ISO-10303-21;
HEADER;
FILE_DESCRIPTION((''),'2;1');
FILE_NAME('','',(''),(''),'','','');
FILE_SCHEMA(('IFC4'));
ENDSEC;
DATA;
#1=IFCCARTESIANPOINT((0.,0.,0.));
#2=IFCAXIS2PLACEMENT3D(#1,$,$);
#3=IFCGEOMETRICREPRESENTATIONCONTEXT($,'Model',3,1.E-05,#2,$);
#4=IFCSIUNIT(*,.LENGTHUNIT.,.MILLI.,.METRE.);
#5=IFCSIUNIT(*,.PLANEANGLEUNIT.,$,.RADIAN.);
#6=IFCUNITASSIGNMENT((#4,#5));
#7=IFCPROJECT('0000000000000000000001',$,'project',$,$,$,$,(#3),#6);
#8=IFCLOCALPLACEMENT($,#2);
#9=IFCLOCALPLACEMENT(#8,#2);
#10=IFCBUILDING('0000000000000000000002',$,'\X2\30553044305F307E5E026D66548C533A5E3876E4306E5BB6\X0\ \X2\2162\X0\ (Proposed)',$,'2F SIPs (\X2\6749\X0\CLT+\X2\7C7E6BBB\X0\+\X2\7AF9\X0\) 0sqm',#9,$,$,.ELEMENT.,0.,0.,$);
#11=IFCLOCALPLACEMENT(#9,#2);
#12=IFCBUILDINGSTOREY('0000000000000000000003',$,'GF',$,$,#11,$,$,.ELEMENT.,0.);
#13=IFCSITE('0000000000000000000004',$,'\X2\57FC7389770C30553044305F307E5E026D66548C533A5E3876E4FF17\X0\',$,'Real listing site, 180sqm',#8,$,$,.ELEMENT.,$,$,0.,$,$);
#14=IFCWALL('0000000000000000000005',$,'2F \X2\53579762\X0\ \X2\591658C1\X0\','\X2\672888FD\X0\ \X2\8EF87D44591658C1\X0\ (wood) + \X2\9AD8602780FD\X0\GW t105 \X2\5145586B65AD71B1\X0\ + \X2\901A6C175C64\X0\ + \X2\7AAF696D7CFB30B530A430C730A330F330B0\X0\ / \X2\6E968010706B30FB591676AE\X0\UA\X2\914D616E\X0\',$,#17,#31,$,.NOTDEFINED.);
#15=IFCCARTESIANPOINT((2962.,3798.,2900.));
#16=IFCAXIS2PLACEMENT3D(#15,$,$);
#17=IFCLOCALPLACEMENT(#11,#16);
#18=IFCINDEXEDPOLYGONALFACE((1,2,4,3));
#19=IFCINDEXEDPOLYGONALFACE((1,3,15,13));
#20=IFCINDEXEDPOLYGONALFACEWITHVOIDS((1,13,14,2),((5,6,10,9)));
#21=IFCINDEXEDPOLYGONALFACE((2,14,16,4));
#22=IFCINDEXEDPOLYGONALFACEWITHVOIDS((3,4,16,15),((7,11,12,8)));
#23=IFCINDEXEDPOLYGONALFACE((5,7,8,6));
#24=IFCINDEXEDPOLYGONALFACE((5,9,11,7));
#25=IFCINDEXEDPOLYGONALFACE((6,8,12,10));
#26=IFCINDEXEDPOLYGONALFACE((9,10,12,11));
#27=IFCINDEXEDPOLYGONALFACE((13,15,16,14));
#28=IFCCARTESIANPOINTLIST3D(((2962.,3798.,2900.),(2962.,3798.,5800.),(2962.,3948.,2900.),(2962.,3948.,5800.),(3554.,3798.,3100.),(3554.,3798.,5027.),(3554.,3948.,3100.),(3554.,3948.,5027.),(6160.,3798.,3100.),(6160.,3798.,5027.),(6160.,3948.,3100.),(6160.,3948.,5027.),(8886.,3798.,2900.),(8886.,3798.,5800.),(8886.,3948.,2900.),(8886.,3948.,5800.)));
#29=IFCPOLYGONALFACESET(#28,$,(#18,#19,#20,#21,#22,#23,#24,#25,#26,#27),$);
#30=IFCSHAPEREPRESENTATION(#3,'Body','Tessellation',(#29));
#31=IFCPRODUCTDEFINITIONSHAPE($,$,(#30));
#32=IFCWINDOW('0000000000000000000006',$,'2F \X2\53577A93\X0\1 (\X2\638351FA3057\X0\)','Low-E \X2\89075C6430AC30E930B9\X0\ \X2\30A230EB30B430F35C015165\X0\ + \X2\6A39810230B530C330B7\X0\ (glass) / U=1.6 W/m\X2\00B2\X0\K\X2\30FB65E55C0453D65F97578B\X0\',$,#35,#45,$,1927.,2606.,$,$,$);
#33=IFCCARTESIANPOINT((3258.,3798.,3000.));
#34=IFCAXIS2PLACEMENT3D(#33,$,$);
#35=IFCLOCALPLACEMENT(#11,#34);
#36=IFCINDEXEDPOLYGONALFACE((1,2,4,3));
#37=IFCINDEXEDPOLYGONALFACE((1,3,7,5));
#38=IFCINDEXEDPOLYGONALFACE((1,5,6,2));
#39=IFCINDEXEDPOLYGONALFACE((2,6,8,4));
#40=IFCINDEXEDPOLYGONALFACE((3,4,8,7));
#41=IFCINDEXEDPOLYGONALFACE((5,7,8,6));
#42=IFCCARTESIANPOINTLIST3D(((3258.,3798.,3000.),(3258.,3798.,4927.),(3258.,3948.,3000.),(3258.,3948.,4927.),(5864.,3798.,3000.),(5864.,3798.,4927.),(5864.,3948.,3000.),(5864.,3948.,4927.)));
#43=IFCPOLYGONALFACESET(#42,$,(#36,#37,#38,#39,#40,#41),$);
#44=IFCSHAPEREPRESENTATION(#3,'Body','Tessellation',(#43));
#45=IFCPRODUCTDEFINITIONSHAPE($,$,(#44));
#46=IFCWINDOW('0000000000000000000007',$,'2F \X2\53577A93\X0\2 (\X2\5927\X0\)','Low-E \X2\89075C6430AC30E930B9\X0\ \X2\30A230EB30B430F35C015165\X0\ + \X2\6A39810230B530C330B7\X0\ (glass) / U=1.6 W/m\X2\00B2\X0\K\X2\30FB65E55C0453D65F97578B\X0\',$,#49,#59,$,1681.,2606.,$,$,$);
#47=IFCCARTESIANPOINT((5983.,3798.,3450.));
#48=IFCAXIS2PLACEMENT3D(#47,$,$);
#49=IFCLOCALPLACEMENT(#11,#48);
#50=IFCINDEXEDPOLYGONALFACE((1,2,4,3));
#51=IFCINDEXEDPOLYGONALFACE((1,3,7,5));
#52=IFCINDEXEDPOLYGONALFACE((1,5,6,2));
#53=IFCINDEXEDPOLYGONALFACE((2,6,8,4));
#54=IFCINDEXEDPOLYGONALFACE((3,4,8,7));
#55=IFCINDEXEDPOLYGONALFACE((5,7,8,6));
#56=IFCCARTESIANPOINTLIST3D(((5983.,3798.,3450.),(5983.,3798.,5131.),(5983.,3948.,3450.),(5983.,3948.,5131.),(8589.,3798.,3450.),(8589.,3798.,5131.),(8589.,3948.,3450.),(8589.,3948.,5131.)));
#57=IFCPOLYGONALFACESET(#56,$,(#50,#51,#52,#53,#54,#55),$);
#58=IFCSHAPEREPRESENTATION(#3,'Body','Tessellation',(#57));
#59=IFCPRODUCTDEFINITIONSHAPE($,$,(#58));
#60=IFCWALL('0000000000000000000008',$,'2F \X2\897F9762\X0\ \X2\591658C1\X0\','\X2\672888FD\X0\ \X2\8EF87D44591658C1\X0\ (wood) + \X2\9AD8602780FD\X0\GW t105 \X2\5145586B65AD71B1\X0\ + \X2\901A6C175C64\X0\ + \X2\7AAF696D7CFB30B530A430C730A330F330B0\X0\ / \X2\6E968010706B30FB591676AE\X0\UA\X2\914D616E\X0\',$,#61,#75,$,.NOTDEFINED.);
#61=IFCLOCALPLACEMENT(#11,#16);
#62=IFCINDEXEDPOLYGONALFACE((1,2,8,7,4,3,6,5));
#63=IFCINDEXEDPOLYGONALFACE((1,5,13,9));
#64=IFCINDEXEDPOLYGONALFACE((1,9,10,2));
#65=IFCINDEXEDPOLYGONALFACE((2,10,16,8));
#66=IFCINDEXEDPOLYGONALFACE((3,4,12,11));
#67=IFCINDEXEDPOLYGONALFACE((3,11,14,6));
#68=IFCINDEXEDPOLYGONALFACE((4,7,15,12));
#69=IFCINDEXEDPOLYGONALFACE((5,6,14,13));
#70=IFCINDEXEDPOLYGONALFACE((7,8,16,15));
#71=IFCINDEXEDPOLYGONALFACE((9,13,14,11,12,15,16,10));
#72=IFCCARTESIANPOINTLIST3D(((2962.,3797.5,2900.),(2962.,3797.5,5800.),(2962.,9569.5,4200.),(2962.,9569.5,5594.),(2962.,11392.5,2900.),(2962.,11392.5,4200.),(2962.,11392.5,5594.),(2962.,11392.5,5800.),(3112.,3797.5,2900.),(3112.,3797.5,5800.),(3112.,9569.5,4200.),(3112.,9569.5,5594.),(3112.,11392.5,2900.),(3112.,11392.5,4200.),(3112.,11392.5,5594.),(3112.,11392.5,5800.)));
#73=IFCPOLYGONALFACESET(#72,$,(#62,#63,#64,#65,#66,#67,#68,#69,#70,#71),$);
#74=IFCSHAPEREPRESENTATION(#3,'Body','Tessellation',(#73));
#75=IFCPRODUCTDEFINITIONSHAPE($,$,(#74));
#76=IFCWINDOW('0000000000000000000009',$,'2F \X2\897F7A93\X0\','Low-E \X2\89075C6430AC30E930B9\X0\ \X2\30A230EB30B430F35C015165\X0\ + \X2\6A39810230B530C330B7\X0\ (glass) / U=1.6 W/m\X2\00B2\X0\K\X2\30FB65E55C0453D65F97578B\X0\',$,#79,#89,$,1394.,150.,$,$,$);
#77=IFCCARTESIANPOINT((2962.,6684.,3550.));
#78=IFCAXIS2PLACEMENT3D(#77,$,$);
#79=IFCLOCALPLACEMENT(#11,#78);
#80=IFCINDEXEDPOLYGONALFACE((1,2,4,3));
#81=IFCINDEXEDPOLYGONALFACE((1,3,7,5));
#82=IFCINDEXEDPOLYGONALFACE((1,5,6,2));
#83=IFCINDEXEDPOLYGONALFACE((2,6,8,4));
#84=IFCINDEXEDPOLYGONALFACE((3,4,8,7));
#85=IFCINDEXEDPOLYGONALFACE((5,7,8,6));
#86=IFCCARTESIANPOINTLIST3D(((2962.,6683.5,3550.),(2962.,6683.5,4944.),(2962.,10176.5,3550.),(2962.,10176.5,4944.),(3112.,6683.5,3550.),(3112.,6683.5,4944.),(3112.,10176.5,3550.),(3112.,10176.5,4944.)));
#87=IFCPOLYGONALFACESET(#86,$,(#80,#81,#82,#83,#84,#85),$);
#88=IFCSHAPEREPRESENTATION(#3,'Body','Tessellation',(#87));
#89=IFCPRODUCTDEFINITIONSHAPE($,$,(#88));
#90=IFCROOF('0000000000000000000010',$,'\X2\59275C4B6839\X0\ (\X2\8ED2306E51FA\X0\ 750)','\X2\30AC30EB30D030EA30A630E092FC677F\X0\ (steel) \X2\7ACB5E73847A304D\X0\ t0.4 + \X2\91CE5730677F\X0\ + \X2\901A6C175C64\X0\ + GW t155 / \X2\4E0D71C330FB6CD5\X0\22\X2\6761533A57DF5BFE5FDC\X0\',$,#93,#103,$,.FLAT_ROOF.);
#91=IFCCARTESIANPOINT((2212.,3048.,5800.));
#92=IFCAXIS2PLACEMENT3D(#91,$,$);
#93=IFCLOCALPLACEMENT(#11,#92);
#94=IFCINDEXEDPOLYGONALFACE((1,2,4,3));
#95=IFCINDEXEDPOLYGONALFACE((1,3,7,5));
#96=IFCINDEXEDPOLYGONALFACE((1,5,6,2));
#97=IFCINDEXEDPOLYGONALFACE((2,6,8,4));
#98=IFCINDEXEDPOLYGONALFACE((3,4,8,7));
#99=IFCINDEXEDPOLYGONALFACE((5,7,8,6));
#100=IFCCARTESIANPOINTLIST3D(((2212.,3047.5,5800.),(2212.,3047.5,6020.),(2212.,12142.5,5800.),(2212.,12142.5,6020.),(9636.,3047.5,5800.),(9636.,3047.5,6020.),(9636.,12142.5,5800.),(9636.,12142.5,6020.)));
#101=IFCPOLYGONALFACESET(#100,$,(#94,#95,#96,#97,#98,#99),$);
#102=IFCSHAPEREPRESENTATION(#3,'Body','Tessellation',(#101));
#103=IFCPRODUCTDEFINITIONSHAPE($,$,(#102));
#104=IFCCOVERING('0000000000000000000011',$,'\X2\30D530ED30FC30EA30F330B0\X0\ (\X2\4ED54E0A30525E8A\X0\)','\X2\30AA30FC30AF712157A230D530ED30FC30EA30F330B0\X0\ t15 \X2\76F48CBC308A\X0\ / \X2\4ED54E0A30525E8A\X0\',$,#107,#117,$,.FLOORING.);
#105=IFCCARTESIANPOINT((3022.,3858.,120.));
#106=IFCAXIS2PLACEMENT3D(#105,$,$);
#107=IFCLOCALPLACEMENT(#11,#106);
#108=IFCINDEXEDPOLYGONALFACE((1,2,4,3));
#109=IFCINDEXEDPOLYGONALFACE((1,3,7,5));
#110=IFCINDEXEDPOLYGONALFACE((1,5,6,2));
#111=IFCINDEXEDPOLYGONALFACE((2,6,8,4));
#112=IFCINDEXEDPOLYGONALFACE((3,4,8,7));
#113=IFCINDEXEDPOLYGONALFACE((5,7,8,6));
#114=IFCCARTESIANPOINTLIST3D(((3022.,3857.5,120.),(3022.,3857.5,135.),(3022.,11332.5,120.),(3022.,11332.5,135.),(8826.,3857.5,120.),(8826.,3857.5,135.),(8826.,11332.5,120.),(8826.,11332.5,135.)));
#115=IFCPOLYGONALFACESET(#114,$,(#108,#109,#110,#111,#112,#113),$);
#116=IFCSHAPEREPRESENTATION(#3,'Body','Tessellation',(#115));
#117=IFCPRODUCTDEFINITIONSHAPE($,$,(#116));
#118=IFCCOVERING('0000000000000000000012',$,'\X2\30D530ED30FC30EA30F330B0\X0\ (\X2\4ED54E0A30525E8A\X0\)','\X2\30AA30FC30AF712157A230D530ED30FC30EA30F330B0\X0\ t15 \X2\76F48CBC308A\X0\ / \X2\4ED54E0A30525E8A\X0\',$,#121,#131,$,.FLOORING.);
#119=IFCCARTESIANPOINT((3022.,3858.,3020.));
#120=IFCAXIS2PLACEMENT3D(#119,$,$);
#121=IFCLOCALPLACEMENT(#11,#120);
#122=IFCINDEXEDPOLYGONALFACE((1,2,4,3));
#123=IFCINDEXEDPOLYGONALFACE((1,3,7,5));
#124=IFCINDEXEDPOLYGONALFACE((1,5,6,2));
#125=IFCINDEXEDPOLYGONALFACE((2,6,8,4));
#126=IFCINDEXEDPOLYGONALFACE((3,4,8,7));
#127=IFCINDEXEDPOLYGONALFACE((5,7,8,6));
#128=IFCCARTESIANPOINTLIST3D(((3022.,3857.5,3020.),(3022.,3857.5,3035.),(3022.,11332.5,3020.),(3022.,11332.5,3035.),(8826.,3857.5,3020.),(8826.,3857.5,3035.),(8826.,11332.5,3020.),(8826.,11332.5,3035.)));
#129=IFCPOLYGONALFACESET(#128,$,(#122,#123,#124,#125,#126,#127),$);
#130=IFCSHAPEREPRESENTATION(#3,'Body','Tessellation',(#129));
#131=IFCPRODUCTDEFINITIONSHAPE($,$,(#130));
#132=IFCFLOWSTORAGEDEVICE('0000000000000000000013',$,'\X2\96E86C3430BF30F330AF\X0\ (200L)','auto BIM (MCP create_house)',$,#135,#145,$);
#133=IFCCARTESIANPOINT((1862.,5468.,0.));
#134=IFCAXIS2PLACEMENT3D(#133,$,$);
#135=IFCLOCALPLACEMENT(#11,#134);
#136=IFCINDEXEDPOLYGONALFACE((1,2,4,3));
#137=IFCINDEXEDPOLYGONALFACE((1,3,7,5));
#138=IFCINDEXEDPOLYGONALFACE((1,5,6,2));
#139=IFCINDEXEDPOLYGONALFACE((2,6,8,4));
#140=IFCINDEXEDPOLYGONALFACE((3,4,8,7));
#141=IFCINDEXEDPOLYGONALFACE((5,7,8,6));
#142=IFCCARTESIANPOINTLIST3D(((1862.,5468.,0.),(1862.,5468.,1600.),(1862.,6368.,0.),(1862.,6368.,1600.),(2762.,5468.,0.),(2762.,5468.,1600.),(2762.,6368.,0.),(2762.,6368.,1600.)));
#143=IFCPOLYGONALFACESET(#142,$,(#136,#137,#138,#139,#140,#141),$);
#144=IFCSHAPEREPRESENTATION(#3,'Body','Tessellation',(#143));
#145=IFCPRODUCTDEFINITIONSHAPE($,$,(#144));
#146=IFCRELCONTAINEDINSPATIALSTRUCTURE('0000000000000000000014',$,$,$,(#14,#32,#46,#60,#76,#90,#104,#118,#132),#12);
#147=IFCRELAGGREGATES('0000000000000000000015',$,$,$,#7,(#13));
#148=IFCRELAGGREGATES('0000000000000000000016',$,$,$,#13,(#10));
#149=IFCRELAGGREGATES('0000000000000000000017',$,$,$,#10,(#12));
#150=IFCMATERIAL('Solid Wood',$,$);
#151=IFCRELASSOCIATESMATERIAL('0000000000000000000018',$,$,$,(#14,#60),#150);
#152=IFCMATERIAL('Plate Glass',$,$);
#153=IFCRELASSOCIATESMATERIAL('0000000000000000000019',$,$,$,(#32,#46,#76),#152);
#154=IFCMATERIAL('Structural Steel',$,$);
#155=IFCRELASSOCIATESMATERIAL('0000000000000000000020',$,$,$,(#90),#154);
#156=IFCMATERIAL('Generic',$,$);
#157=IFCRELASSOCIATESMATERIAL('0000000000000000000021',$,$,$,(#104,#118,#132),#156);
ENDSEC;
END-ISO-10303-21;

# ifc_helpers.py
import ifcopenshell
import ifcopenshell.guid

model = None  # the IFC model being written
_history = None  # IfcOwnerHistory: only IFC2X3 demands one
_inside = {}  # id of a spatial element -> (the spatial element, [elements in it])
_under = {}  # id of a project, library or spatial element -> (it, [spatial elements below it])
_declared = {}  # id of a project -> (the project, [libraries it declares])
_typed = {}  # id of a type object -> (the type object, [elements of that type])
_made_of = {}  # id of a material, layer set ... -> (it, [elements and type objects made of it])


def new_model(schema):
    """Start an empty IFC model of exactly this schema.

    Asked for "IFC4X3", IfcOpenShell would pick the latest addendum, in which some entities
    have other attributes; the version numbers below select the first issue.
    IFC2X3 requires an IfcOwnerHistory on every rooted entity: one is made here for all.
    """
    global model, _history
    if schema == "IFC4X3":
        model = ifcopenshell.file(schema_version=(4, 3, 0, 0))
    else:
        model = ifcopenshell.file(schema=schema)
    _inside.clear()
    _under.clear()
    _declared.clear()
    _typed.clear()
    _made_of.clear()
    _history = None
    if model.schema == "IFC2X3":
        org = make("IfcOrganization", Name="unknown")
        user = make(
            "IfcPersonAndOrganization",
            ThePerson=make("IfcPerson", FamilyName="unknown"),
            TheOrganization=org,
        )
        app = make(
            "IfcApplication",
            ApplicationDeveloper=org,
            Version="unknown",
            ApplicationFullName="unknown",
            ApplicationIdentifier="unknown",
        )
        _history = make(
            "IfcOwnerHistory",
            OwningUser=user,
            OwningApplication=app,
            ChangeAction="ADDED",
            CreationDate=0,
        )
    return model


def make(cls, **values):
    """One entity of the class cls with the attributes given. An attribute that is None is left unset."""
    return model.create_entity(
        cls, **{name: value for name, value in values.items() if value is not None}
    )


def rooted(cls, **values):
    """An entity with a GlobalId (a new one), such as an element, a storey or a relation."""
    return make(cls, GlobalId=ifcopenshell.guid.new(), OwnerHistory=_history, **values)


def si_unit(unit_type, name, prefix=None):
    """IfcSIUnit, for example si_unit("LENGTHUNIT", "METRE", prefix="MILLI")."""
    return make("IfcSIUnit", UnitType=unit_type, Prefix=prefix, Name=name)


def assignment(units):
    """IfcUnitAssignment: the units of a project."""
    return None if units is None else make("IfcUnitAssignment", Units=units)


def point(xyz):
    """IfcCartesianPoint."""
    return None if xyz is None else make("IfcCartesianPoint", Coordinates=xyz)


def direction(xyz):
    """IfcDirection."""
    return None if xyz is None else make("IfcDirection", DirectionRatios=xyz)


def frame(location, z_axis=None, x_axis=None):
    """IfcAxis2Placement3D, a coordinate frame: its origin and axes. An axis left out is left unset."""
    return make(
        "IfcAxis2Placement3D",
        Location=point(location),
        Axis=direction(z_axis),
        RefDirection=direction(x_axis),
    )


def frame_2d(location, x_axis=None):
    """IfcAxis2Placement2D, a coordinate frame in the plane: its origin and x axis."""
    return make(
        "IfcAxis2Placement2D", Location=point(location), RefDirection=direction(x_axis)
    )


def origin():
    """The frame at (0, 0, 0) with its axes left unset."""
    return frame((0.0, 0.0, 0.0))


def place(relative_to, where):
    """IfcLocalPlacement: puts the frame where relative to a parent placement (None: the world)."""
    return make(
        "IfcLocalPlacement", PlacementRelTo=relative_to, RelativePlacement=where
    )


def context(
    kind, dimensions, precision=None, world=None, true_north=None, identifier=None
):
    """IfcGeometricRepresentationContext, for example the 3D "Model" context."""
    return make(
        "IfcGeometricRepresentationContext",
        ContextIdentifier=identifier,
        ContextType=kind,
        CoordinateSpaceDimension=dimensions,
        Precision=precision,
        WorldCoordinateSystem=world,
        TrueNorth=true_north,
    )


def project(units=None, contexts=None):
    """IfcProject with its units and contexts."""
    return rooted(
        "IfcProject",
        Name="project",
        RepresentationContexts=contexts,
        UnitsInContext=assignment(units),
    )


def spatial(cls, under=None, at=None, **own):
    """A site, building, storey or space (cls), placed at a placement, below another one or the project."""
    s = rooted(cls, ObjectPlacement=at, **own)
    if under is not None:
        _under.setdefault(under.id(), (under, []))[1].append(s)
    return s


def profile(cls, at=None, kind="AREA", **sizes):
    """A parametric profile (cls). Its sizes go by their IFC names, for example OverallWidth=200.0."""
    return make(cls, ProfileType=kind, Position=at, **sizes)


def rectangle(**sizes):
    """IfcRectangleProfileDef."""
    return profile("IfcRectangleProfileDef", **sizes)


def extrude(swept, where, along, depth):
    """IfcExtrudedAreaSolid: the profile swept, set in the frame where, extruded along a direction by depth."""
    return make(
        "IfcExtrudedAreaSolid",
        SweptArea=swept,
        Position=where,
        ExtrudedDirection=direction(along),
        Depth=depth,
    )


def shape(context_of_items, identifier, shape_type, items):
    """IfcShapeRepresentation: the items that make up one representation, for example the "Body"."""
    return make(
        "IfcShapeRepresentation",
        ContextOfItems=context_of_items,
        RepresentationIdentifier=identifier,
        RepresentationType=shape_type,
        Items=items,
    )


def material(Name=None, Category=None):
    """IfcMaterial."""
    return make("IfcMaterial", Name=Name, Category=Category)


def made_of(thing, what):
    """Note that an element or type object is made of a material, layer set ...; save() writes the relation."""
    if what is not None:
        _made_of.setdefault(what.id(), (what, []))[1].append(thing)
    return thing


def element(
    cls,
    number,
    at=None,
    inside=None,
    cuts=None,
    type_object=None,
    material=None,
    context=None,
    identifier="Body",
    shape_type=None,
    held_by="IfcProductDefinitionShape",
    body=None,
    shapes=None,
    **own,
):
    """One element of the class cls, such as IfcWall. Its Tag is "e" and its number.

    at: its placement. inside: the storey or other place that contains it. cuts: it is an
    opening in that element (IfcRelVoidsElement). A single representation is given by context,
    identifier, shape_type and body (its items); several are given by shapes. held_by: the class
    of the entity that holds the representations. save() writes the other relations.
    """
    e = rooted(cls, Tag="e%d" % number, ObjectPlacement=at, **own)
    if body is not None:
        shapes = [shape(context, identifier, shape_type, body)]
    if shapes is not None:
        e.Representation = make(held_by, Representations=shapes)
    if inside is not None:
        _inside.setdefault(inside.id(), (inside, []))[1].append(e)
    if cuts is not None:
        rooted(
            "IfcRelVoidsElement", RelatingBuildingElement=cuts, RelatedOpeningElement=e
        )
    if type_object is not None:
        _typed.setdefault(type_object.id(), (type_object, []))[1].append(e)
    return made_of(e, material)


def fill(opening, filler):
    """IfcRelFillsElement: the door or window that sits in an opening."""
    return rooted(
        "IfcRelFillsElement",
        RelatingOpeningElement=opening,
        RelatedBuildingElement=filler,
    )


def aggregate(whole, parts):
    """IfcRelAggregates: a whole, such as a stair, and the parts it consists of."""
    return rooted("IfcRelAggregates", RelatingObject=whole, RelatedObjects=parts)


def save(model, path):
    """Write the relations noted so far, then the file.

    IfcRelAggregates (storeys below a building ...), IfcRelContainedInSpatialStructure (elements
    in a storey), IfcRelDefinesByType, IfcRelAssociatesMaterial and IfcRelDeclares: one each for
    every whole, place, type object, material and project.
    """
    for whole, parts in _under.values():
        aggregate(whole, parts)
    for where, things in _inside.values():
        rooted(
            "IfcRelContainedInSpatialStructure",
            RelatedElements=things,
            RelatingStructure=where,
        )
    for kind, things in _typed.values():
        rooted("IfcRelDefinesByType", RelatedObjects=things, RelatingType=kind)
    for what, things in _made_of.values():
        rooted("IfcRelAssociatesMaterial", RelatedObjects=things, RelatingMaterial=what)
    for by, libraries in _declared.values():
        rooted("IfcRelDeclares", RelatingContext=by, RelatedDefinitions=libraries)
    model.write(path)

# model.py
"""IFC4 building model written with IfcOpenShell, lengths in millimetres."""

from ifc_helpers import new_model, si_unit, frame, frame_2d, origin, place, context, project, spatial, rectangle, extrude, material, element, fill, save


model = new_model("IFC4")

# Units and contexts
model_context = context("Model", 3, precision=1e-05, world=origin())
ifc_project = project(units=[si_unit("LENGTHUNIT", "METRE", prefix="MILLI"), si_unit("PLANEANGLEUNIT", "RADIAN")], contexts=[model_context])

# Site, building, storey
site_placement = place(None, origin())
site = spatial("IfcSite", under=ifc_project, at=site_placement, Name="埼玉県さいたま市浦和区常盤７", ObjectType="Real listing site, 180sqm", CompositionType="ELEMENT", RefElevation=0.0)
building_placement = place(site_placement, origin())
building = spatial("IfcBuilding", under=site, at=building_placement, Name="さいたま市浦和区常盤の家 Ⅲ (Proposed)", ObjectType="2F SIPs (杉CLT+籾殻+竹) 0sqm", CompositionType="ELEMENT", ElevationOfRefHeight=0.0, ElevationOfTerrain=0.0)
storey_placement = place(building_placement, origin())
storey = spatial("IfcBuildingStorey", under=building, at=storey_placement, Name="GF", CompositionType="ELEMENT", Elevation=0.0)

# Shared definitions
ifc_material_1 = material(Name="Solid Wood")

# Shared definitions
ifc_material_2 = material(Name="Plate Glass")

# Wall, openings, windows
wall_1_placement = place(storey_placement, frame((2962.0, 3798.0, 2900.0)))
wall_1 = element("IfcWall", 1, at=wall_1_placement, inside=storey, material=ifc_material_1, Name="2F 南面 外壁", Description="木製 軸組外壁 (wood) + 高性能GW t105 充填断熱 + 通気層 + 窯業系サイディング / 準耐火・外皮UA配慮", PredefinedType="NOTDEFINED", context=model_context, shape_type="SweptSolid", body=[
    extrude(rectangle(XDim=5924.0, YDim=150.0, at=frame_2d((2962.0, 75.0))), frame((2962.0, 3798.0, 2900.0)), (0.0, 0.0, 1.0), 2900.0),
])
opening_1_placement = place(storey_placement, frame((3258.0, 3798.0, 3000.0)))
opening_1 = element("IfcOpeningElement", 2, at=opening_1_placement, cuts=wall_1, PredefinedType="NOTDEFINED", context=model_context, shape_type="SweptSolid", body=[
    extrude(rectangle(XDim=2606.0, YDim=150.0, at=frame_2d((1303.0, 75.0))), frame((3258.0, 3798.0, 3000.0)), (0.0, 0.0, 1.0), 1927.0),
])
opening_2_placement = place(storey_placement, frame((5983.0, 3798.0, 3450.0)))
opening_2 = element("IfcOpeningElement", 3, at=opening_2_placement, cuts=wall_1, PredefinedType="NOTDEFINED", context=model_context, shape_type="SweptSolid", body=[
    extrude(rectangle(XDim=2606.0, YDim=150.0, at=frame_2d((1303.0, 75.0))), frame((5983.0, 3798.0, 3450.0)), (0.0, 0.0, 1.0), 1681.0),
])
window_1_placement = place(storey_placement, frame((3258.0, 3798.0, 3000.0)))
window_1 = element("IfcWindow", 4, at=window_1_placement, inside=storey, material=ifc_material_2, Name="2F 南窓1 (掃出し)", Description="Low-E 複層ガラス アルゴン封入 + 樹脂サッシ (glass) / U=1.6 W/m²K・日射取得型", OverallHeight=1927.0, OverallWidth=2606.0, context=model_context, shape_type="SweptSolid", body=[
    extrude(rectangle(XDim=2606.0, YDim=150.0, at=frame_2d((1303.0, 75.0))), frame((3258.0, 3798.0, 3000.0)), (0.0, 0.0, 1.0), 1927.0),
])
fill(opening_1, window_1)
window_2_placement = place(storey_placement, frame((5983.0, 3798.0, 3450.0)))
window_2 = element("IfcWindow", 5, at=window_2_placement, inside=storey, material=ifc_material_2, Name="2F 南窓2 (大)", Description="Low-E 複層ガラス アルゴン封入 + 樹脂サッシ (glass) / U=1.6 W/m²K・日射取得型", OverallHeight=1681.0, OverallWidth=2606.0, context=model_context, shape_type="SweptSolid", body=[
    extrude(rectangle(XDim=2606.0, YDim=150.0, at=frame_2d((1303.0, 75.0))), frame((5983.0, 3798.0, 3450.0)), (0.0, 0.0, 1.0), 1681.0),
])
fill(opening_2, window_2)

# Wall, opening, window
wall_2_placement = place(storey_placement, frame((2962.0, 3798.0, 2900.0)))
wall_2 = element("IfcWall", 6, at=wall_2_placement, inside=storey, material=ifc_material_1, Name="2F 西面 外壁", Description="木製 軸組外壁 (wood) + 高性能GW t105 充填断熱 + 通気層 + 窯業系サイディング / 準耐火・外皮UA配慮", PredefinedType="NOTDEFINED", context=model_context, shape_type="SweptSolid", body=[
    extrude(rectangle(XDim=150.0, YDim=7595.0, at=frame_2d((75.0, 3797.0))), frame((2962.0, 3798.0, 2900.0)), (0.0, 0.0, 1.0), 2900.0),
])
opening_3_placement = place(storey_placement, frame((2962.0, 6684.0, 3550.0)))
opening_3 = element("IfcOpeningElement", 7, at=opening_3_placement, cuts=wall_2, PredefinedType="NOTDEFINED", context=model_context, shape_type="SweptSolid", body=[
    extrude(rectangle(XDim=150.0, YDim=3493.0, at=frame_2d((75.0, 1746.0))), frame((2962.0, 6684.0, 3550.0)), (0.0, 0.0, 1.0), 1394.0),
])
window_3_placement = place(storey_placement, frame((2962.0, 6684.0, 3550.0)))
window_3 = element("IfcWindow", 8, at=window_3_placement, inside=storey, material=ifc_material_2, Name="2F 西窓", Description="Low-E 複層ガラス アルゴン封入 + 樹脂サッシ (glass) / U=1.6 W/m²K・日射取得型", OverallHeight=1394.0, OverallWidth=150.0, context=model_context, shape_type="SweptSolid", body=[
    extrude(rectangle(XDim=150.0, YDim=3493.0, at=frame_2d((75.0, 1746.0))), frame((2962.0, 6684.0, 3550.0)), (0.0, 0.0, 1.0), 1394.0),
])
fill(opening_3, window_3)

# Roof
ifc_material_3 = material(Name="Structural Steel")
roof_placement = place(storey_placement, frame((2212.0, 3048.0, 5800.0)))
element("IfcRoof", 9, at=roof_placement, inside=storey, material=ifc_material_3, Name="大屋根 (軒の出 750)", Description="ガルバリウム鋼板 (steel) 立平葺き t0.4 + 野地板 + 通気層 + GW t155 / 不燃・法22条区域対応", PredefinedType="FLAT_ROOF", context=model_context, shape_type="SweptSolid", body=[
    extrude(rectangle(XDim=7424.0, YDim=9095.0, at=frame_2d((3712.0, 4547.0))), frame((2212.0, 3048.0, 5800.0)), (0.0, 0.0, 1.0), 220.0),
])

# Coverings
ifc_material_4 = material(Name="Generic")
covering_1_placement = place(storey_placement, frame((3022.0, 3858.0, 120.0)))
element("IfcCovering", 10, at=covering_1_placement, inside=storey, material=ifc_material_4, Name="フローリング (仕上げ床)", Description="オーク無垢フローリング t15 直貼り / 仕上げ床", PredefinedType="FLOORING", context=model_context, shape_type="SweptSolid", body=[
    extrude(rectangle(XDim=5804.0, YDim=7475.0, at=frame_2d((2902.0, 3737.0))), frame((3022.0, 3858.0, 120.0)), (0.0, 0.0, 1.0), 15.0),
])
covering_2_placement = place(storey_placement, frame((3022.0, 3858.0, 3020.0)))
element("IfcCovering", 11, at=covering_2_placement, inside=storey, material=ifc_material_4, Name="フローリング (仕上げ床)", Description="オーク無垢フローリング t15 直貼り / 仕上げ床", PredefinedType="FLOORING", context=model_context, shape_type="SweptSolid", body=[
    extrude(rectangle(XDim=5804.0, YDim=7475.0, at=frame_2d((2902.0, 3737.0))), frame((3022.0, 3858.0, 3020.0)), (0.0, 0.0, 1.0), 15.0),
])

# Flow storage device
flow_storage_device_placement = place(storey_placement, frame((1862.0, 5468.0, 0.0)))
element("IfcFlowStorageDevice", 12, at=flow_storage_device_placement, inside=storey, material=ifc_material_4, Name="雨水タンク (200L)", Description="auto BIM (MCP create_house)", context=model_context, shape_type="SweptSolid", body=[
    extrude(rectangle(XDim=900.0, YDim=900.0, at=frame_2d((450.0, 450.0))), frame((1862.0, 5468.0, 0.0)), (0.0, 0.0, 1.0), 1600.0),
])

save(model, "model.ifc")
